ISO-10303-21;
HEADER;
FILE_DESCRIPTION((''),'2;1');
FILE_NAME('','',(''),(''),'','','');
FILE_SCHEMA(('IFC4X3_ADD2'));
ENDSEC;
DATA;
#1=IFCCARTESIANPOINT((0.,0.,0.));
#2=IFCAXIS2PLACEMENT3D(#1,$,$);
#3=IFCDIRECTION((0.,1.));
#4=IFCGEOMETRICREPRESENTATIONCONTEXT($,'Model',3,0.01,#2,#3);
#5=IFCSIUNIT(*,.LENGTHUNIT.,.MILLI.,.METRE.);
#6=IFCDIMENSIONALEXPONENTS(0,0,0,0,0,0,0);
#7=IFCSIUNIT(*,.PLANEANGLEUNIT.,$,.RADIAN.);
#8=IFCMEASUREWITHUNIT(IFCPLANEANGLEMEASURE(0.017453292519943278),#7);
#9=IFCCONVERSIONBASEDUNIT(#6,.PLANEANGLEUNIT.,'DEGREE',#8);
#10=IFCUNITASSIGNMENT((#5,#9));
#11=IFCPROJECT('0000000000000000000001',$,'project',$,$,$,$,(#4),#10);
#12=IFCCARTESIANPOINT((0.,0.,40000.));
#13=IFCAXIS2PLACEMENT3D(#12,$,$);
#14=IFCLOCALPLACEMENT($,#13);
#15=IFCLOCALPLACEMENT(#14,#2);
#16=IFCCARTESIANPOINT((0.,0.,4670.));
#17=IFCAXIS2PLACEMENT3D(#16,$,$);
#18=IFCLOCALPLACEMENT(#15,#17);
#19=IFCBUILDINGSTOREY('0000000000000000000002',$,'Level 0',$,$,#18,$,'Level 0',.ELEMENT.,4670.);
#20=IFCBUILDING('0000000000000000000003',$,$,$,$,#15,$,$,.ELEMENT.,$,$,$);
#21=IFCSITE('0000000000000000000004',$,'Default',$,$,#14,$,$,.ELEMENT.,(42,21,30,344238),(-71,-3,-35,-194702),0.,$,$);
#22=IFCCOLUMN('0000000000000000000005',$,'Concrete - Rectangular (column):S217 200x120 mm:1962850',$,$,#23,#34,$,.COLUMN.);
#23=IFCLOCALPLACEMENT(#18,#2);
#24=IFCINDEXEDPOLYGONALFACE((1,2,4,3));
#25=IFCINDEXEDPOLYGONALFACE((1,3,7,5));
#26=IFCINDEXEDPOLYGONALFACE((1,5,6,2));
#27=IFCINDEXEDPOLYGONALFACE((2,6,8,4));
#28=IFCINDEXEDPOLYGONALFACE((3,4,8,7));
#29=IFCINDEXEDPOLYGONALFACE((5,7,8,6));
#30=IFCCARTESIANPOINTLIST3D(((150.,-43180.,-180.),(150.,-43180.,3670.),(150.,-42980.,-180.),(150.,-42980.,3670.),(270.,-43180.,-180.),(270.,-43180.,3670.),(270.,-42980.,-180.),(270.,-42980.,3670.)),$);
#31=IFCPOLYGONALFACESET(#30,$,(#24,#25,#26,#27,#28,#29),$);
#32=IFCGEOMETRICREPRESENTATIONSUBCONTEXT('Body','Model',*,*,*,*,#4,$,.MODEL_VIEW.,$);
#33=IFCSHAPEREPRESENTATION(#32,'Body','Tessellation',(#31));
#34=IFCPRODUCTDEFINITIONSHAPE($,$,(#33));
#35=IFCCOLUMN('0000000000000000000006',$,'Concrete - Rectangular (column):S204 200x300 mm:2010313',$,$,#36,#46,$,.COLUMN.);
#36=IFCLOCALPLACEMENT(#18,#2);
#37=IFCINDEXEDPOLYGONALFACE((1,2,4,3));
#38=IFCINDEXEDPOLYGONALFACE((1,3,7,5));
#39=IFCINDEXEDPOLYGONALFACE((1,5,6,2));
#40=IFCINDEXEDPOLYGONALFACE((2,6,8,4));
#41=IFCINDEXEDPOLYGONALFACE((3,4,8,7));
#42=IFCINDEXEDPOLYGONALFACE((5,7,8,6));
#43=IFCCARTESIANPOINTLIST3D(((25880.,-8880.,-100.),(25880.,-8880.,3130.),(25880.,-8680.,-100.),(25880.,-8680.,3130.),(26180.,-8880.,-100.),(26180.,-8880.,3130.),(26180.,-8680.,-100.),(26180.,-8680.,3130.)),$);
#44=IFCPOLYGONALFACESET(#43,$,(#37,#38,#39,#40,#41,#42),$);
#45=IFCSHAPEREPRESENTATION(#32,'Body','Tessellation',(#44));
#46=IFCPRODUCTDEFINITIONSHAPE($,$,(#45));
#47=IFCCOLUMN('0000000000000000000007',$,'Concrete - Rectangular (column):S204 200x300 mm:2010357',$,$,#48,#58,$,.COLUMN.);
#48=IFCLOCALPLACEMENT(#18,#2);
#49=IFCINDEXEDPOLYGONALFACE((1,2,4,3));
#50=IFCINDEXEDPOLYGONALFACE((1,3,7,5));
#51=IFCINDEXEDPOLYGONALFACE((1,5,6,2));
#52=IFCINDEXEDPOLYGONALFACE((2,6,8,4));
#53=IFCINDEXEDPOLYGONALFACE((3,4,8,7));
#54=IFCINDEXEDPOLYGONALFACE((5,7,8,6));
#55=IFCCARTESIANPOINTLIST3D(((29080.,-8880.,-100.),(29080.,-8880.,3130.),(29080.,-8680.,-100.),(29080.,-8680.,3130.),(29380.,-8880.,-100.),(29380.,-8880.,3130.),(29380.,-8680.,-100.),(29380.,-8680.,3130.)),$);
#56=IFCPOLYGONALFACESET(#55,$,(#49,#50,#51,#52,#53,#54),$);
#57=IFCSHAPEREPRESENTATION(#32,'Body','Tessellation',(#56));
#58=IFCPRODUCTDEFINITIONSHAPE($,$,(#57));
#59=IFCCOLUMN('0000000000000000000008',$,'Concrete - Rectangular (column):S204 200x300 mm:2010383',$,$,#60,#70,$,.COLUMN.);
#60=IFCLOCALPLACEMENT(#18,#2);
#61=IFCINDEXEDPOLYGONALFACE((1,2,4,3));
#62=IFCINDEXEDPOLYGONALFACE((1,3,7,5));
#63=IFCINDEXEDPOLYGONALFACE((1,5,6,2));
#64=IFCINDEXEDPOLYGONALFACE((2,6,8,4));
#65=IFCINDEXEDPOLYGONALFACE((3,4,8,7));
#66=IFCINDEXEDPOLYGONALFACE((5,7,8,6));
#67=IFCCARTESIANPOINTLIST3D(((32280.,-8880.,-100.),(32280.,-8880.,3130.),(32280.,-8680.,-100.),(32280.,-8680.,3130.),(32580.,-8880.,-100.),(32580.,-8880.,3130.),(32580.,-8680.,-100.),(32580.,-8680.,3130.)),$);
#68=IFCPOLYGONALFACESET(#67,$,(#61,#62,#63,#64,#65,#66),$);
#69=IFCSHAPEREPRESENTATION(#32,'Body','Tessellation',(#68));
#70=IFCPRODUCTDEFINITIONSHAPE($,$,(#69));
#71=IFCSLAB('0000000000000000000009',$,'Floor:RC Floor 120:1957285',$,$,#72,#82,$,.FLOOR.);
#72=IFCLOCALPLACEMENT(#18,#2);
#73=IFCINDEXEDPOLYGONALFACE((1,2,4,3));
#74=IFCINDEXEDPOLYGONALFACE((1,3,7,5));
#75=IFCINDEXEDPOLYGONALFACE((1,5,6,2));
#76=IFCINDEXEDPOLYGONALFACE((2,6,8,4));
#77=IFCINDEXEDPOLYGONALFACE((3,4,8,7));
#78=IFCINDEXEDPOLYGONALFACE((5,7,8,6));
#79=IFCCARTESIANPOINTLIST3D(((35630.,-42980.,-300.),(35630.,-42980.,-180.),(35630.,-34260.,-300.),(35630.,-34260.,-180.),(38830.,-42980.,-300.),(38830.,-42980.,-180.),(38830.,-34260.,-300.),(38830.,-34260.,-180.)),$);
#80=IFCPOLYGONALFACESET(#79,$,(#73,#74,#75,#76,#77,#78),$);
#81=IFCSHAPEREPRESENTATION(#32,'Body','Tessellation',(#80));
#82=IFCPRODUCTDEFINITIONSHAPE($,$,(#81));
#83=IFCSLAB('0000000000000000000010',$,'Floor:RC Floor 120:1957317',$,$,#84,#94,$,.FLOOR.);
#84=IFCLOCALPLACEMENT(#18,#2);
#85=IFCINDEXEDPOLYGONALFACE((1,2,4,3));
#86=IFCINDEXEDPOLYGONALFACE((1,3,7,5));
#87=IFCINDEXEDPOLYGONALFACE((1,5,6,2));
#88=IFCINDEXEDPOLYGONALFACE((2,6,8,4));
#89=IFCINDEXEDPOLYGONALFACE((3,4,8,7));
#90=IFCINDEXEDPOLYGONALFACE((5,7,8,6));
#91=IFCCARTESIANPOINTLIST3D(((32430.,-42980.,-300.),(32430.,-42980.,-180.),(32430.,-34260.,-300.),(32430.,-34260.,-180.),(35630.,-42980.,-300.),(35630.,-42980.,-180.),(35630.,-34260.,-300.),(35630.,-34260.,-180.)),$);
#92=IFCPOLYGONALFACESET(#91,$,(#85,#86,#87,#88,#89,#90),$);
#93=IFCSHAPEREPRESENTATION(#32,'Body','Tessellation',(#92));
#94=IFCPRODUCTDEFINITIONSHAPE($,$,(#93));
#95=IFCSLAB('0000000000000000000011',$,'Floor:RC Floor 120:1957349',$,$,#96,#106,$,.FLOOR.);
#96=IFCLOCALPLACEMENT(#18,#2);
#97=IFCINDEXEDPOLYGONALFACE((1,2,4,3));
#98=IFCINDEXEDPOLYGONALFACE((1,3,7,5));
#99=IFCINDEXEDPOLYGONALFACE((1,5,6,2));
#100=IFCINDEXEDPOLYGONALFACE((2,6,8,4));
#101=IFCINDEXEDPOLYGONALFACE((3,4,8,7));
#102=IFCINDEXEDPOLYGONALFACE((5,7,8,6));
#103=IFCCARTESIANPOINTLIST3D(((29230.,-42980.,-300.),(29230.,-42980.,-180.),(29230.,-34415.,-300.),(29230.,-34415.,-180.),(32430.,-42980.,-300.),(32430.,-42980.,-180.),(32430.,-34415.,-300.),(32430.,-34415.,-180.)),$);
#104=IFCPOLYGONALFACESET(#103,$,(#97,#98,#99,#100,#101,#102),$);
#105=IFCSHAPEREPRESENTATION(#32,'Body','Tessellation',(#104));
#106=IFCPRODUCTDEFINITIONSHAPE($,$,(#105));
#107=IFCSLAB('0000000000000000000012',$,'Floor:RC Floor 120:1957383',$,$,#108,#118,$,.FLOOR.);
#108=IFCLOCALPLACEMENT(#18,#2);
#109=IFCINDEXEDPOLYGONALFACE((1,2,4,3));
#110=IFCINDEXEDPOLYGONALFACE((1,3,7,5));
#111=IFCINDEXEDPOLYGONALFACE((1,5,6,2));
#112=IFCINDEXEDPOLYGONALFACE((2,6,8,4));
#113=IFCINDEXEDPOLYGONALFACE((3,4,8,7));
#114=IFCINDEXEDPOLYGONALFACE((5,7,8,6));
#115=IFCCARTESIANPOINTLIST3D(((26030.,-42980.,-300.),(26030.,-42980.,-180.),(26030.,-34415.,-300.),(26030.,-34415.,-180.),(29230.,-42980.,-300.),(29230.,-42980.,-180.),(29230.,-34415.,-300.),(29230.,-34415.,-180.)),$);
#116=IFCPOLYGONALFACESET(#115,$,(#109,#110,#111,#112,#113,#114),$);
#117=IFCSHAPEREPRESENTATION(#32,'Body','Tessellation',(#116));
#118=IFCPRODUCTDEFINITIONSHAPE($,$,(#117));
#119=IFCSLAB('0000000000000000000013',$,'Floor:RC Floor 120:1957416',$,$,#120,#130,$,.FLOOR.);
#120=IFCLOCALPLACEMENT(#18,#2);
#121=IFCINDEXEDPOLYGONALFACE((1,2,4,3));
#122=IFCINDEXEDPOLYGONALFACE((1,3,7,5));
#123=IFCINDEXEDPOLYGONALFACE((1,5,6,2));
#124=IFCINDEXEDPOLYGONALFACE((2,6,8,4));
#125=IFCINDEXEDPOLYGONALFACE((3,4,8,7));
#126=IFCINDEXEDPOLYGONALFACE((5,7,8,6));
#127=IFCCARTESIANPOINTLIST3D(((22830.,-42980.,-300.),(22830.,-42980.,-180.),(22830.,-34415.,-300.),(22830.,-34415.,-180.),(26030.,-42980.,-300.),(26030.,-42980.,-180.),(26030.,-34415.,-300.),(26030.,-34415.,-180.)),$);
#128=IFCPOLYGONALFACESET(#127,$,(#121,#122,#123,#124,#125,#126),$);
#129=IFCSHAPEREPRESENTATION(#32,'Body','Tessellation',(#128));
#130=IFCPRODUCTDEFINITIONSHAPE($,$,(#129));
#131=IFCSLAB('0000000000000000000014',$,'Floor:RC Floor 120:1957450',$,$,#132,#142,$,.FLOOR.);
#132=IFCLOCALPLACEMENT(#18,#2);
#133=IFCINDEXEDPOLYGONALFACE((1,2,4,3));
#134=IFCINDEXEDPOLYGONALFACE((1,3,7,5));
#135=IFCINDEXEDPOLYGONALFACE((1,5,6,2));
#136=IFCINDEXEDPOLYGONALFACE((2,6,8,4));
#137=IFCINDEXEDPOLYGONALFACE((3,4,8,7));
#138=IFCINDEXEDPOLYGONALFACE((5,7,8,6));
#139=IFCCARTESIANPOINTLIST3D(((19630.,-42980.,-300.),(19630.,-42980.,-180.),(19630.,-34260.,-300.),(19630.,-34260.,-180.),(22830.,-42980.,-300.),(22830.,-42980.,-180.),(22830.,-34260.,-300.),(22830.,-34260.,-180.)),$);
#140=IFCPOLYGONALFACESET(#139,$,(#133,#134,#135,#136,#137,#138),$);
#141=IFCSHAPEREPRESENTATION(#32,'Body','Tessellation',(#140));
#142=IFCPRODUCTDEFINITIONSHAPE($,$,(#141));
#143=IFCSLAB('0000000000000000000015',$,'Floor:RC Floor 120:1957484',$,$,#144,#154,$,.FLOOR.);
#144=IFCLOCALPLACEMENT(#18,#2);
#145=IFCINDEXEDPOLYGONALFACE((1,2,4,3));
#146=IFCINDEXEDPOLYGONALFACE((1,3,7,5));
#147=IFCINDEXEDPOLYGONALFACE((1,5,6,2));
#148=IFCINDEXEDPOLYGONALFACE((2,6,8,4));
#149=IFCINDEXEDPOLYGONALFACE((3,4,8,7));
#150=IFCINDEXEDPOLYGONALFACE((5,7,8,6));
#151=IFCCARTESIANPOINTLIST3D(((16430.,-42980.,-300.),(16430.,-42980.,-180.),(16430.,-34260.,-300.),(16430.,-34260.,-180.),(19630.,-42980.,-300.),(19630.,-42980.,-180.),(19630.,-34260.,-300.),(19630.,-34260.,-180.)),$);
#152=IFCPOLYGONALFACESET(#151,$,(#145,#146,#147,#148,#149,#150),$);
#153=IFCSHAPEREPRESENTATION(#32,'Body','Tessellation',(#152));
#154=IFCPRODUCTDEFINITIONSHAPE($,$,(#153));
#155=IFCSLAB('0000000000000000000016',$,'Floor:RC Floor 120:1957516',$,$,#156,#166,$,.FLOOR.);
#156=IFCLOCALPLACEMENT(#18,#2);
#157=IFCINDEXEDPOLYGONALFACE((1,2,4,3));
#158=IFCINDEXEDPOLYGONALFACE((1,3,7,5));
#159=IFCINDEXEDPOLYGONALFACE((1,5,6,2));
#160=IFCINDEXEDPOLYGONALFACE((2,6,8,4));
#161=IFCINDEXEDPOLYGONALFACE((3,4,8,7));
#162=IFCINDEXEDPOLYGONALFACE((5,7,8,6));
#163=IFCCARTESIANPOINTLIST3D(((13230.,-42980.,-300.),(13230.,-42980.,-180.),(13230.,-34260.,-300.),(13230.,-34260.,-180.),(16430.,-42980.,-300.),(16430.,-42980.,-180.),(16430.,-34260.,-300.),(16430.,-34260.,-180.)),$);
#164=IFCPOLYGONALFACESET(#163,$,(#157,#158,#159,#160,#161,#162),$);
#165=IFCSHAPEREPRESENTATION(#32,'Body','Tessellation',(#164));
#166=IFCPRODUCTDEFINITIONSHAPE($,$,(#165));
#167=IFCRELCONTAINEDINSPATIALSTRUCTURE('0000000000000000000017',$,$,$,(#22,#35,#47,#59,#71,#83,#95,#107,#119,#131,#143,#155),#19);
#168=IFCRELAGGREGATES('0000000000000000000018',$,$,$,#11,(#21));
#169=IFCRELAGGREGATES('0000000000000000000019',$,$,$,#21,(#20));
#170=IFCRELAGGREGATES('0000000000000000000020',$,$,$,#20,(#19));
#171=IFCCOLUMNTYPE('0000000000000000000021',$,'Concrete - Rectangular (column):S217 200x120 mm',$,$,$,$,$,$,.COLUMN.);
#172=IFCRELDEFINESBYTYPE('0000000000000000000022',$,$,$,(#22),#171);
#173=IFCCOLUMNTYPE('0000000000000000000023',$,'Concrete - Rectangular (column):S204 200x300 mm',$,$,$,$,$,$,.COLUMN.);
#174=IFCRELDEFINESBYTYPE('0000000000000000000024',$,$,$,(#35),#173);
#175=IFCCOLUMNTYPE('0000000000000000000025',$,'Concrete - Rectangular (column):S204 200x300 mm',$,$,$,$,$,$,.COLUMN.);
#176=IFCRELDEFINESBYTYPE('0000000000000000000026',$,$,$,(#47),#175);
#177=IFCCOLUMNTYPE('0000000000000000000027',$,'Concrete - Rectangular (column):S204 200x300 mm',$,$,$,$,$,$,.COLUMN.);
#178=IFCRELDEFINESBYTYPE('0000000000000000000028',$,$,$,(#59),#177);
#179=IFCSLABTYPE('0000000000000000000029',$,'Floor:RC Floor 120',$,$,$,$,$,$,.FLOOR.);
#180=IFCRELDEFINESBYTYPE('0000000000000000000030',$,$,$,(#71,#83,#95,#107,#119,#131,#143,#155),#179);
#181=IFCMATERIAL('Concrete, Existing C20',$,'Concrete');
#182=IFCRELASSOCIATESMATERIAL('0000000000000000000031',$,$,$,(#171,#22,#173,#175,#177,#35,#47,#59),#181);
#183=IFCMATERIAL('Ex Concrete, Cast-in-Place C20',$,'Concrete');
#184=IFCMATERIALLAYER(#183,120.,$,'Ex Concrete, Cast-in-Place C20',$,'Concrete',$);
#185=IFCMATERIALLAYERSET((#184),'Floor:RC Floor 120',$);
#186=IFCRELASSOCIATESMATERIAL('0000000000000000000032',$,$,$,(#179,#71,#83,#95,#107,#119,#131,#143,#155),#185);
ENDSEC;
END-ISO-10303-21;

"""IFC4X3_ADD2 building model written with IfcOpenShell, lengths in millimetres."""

from ifc_helpers import new_model, entity, si_unit, converted_unit, direction, frame, frame_2d, origin, origin_2d_with_axis, place, context, subcontext, project, spatial, rectangle, extrude, source, transform, mapped, material, layer, layer_set, layer_usage, material_profile, profile_set, profile_usage, type_object, type_shapes, element, save


model = new_model("IFC4X3_ADD2")

# Units and contexts
model_context = context("Model", 3, precision=0.01, world=origin(), true_north=direction((0.0, 1.0)))
body_context = subcontext(model_context, "Body", "Model", "MODEL_VIEW")
ifc_project = project(units=[si_unit("LENGTHUNIT", "METRE", prefix="MILLI"), converted_unit("PLANEANGLEUNIT", "DEGREE", entity("IfcPlaneAngleMeasure", 0.017453292519943278), si_unit("PLANEANGLEUNIT", "RADIAN"), dimensions=[0, 0, 0, 0, 0, 0, 0])], contexts=[model_context])

# Site, building, storey
site_placement = place(None, frame((0.0, 0.0, 40000.0)))
site = spatial("IfcSite", under=ifc_project, at=site_placement, Name="Default", CompositionType="ELEMENT", RefLatitude=(42, 21, 30, 344238), RefLongitude=(-71, -3, -35, -194702), RefElevation=0.0)
building_placement = place(site_placement, origin())
building = spatial("IfcBuilding", under=site, at=building_placement, CompositionType="ELEMENT")
storey_placement = place(building_placement, frame((0.0, 0.0, 4670.0)))
storey = spatial("IfcBuildingStorey", under=building, at=storey_placement, Name="Level 0", LongName="Level 0", CompositionType="ELEMENT", Elevation=4670.0)

# Columns
ifc_material_1 = material(Name="Concrete, Existing C20", Category="Concrete")
ifc_material_profile_1 = material_profile(ifc_material_1, rectangle(XDim=200.0, YDim=120.0, at=frame_2d((0.0, 0.0), x_axis=(1.0, 0.0))), Name="S217 200x120 mm")
ifc_profile_set_1 = profile_set([ifc_material_profile_1], Name="S217 200x120 mm")
ifc_profile_usage_1 = profile_usage(ifc_profile_set_1)
column_type_1 = type_object("IfcColumnType", Name="Concrete - Rectangular (column):S217 200x120 mm", PredefinedType="COLUMN", material=ifc_profile_set_1)
shared_shape_1 = source(origin(), body_context, "Body", "SweptSolid", [
    extrude(rectangle(XDim=200.0, YDim=120.0, at=frame_2d((0.0, 0.0), x_axis=(1.0, 0.0))), frame((210.0, -43080.0, 4490.0), z_axis=(0.0, 0.0, 1.0), x_axis=(0.0, 1.0, 0.0)), (0.0, 0.0, 1.0), 3850.0),
])
type_shapes(column_type_1, [shared_shape_1])
column_1_placement = place(storey_placement, frame((0.0, 0.0, -4670.0)))
element("IfcColumn", 1, at=column_1_placement, inside=storey, type_object=column_type_1, material=ifc_profile_usage_1, Name="Concrete - Rectangular (column):S217 200x120 mm:1962850", PredefinedType="COLUMN", context=body_context, shape_type="MappedRepresentation", body=[
    mapped(shared_shape_1, transform((0.0, 0.0, 0.0), scale=1.0)),
])
ifc_material_profile_2 = material_profile(ifc_material_1, rectangle(XDim=200.0, YDim=300.0, at=frame_2d((0.0, 0.0), x_axis=(1.0, 0.0))), Name="S204 200x300 mm")
ifc_profile_set_2 = profile_set([ifc_material_profile_2], Name="S204 200x300 mm")
ifc_profile_usage_2 = profile_usage(ifc_profile_set_2)
column_type_2 = type_object("IfcColumnType", Name="Concrete - Rectangular (column):S204 200x300 mm", PredefinedType="COLUMN", material=ifc_profile_set_2)
shared_shape_2 = source(origin(), body_context, "Body", "SweptSolid", [
    extrude(rectangle(XDim=200.0, YDim=300.0, at=frame_2d((0.0, 0.0), x_axis=(1.0, 0.0))), frame((26030.0, -8780.0, 4570.0), z_axis=(0.0, 0.0, 1.0), x_axis=(0.0, 1.0, 0.0)), (0.0, 0.0, 1.0), 3230.0),
])
type_shapes(column_type_2, [shared_shape_2])
column_2_placement = place(storey_placement, frame((0.0, 0.0, -4670.0)))
element("IfcColumn", 2, at=column_2_placement, inside=storey, type_object=column_type_2, material=ifc_profile_usage_2, Name="Concrete - Rectangular (column):S204 200x300 mm:2010313", PredefinedType="COLUMN", context=body_context, shape_type="MappedRepresentation", body=[
    mapped(shared_shape_2, transform((0.0, 0.0, 0.0), scale=1.0)),
])
column_type_3 = type_object("IfcColumnType", Name="Concrete - Rectangular (column):S204 200x300 mm", PredefinedType="COLUMN", material=ifc_profile_set_2)
shared_shape_3 = source(origin(), body_context, "Body", "SweptSolid", [
    extrude(rectangle(XDim=200.0, YDim=300.0, at=frame_2d((0.0, 0.0), x_axis=(1.0, 0.0))), frame((29230.0, -8780.0, 4570.0), z_axis=(0.0, 0.0, 1.0), x_axis=(0.0, 1.0, 0.0)), (0.0, 0.0, 1.0), 3230.0),
])
type_shapes(column_type_3, [shared_shape_3])
column_3_placement = place(storey_placement, frame((0.0, 0.0, -4670.0)))
element("IfcColumn", 3, at=column_3_placement, inside=storey, type_object=column_type_3, material=ifc_profile_usage_2, Name="Concrete - Rectangular (column):S204 200x300 mm:2010357", PredefinedType="COLUMN", context=body_context, shape_type="MappedRepresentation", body=[
    mapped(shared_shape_3, transform((0.0, 0.0, 0.0), scale=1.0)),
])
column_type_4 = type_object("IfcColumnType", Name="Concrete - Rectangular (column):S204 200x300 mm", PredefinedType="COLUMN", material=ifc_profile_set_2)
shared_shape_4 = source(origin(), body_context, "Body", "SweptSolid", [
    extrude(rectangle(XDim=200.0, YDim=300.0, at=frame_2d((0.0, 0.0), x_axis=(1.0, 0.0))), frame((32430.0, -8780.0, 4570.0), z_axis=(0.0, 0.0, 1.0), x_axis=(0.0, 1.0, 0.0)), (0.0, 0.0, 1.0), 3230.0),
])
type_shapes(column_type_4, [shared_shape_4])
column_4_placement = place(storey_placement, frame((0.0, 0.0, -4670.0)))
element("IfcColumn", 4, at=column_4_placement, inside=storey, type_object=column_type_4, material=ifc_profile_usage_2, Name="Concrete - Rectangular (column):S204 200x300 mm:2010383", PredefinedType="COLUMN", context=body_context, shape_type="MappedRepresentation", body=[
    mapped(shared_shape_4, transform((0.0, 0.0, 0.0), scale=1.0)),
])

# Slabs
ifc_material_2 = material(Name="Ex Concrete, Cast-in-Place C20", Category="Concrete")
ifc_layer_1 = layer(ifc_material_2, 120.0, Name="Ex Concrete, Cast-in-Place C20", Category="Concrete")
ifc_layer_set_1 = layer_set([ifc_layer_1], Name="Floor:RC Floor 120")
ifc_layer_usage_1 = layer_usage(ifc_layer_set_1, "AXIS3", "POSITIVE", 0.0)
slab_type_1 = type_object("IfcSlabType", Name="Floor:RC Floor 120", PredefinedType="FLOOR", material=ifc_layer_set_1)
slab_1_placement = place(storey_placement, origin())
element("IfcSlab", 5, at=slab_1_placement, inside=storey, type_object=slab_type_1, material=ifc_layer_usage_1, Name="Floor:RC Floor 120:1957285", PredefinedType="FLOOR", context=body_context, shape_type="SweptSolid", body=[
    extrude(rectangle(XDim=8720.0, YDim=3200.0, at=frame_2d((0.0, 0.0), x_axis=(1.0, 0.0))), frame((37230.0, -38620.0, -180.0), z_axis=(0.0, 0.0, -1.0), x_axis=(0.0, 1.0, 0.0)), (0.0, 0.0, 1.0), 120.0),
])
ifc_layer_usage_2 = layer_usage(ifc_layer_set_1, "AXIS3", "POSITIVE", 0.0)
slab_2_placement = place(storey_placement, origin())
element("IfcSlab", 6, at=slab_2_placement, inside=storey, type_object=slab_type_1, material=ifc_layer_usage_2, Name="Floor:RC Floor 120:1957317", PredefinedType="FLOOR", context=body_context, shape_type="SweptSolid", body=[
    extrude(rectangle(XDim=8720.0, YDim=3200.0, at=frame_2d((0.0, 0.0), x_axis=(1.0, 0.0))), frame((34030.0, -38620.0, -180.0), z_axis=(0.0, 0.0, -1.0), x_axis=(0.0, 1.0, 0.0)), (0.0, 0.0, 1.0), 120.0),
])
ifc_layer_usage_3 = layer_usage(ifc_layer_set_1, "AXIS3", "POSITIVE", 0.0)
slab_3_placement = place(storey_placement, origin())
element("IfcSlab", 7, at=slab_3_placement, inside=storey, type_object=slab_type_1, material=ifc_layer_usage_3, Name="Floor:RC Floor 120:1957349", PredefinedType="FLOOR", context=body_context, shape_type="SweptSolid", body=[
    extrude(rectangle(XDim=8565.0, YDim=3200.0, at=frame_2d((0.0, 0.0), x_axis=(1.0, 0.0))), frame((30830.0, -38697.5, -180.0), z_axis=(0.0, 0.0, -1.0), x_axis=(0.0, 1.0, 0.0)), (0.0, 0.0, 1.0), 120.0),
])
ifc_layer_usage_4 = layer_usage(ifc_layer_set_1, "AXIS3", "POSITIVE", 0.0)
slab_4_placement = place(storey_placement, origin())
element("IfcSlab", 8, at=slab_4_placement, inside=storey, type_object=slab_type_1, material=ifc_layer_usage_4, Name="Floor:RC Floor 120:1957383", PredefinedType="FLOOR", context=body_context, shape_type="SweptSolid", body=[
    extrude(rectangle(XDim=8565.0, YDim=3200.0, at=frame_2d((0.0, 0.0), x_axis=(1.0, 0.0))), frame((27630.0, -38697.5, -180.0), z_axis=(0.0, 0.0, -1.0), x_axis=(0.0, 1.0, 0.0)), (0.0, 0.0, 1.0), 120.0),
])
ifc_layer_usage_5 = layer_usage(ifc_layer_set_1, "AXIS3", "POSITIVE", 0.0)
slab_5_placement = place(storey_placement, origin())
element("IfcSlab", 9, at=slab_5_placement, inside=storey, type_object=slab_type_1, material=ifc_layer_usage_5, Name="Floor:RC Floor 120:1957416", PredefinedType="FLOOR", context=body_context, shape_type="SweptSolid", body=[
    extrude(rectangle(XDim=8565.0, YDim=3200.0, at=origin_2d_with_axis()), frame((24430.0, -38697.5, -180.0), z_axis=(0.0, 0.0, -1.0), x_axis=(0.0, 1.0, 0.0)), (0.0, 0.0, 1.0), 120.0),
])
ifc_layer_usage_6 = layer_usage(ifc_layer_set_1, "AXIS3", "POSITIVE", 0.0)
slab_6_placement = place(storey_placement, origin())
element("IfcSlab", 10, at=slab_6_placement, inside=storey, type_object=slab_type_1, material=ifc_layer_usage_6, Name="Floor:RC Floor 120:1957450", PredefinedType="FLOOR", context=body_context, shape_type="SweptSolid", body=[
    extrude(rectangle(XDim=8720.0, YDim=3200.0, at=frame_2d((0.0, 0.0), x_axis=(1.0, 0.0))), frame((21230.0, -38620.0, -180.0), z_axis=(0.0, 0.0, -1.0), x_axis=(0.0, 1.0, 0.0)), (0.0, 0.0, 1.0), 120.0),
])
ifc_layer_usage_7 = layer_usage(ifc_layer_set_1, "AXIS3", "POSITIVE", 0.0)
slab_7_placement = place(storey_placement, origin())
element("IfcSlab", 11, at=slab_7_placement, inside=storey, type_object=slab_type_1, material=ifc_layer_usage_7, Name="Floor:RC Floor 120:1957484", PredefinedType="FLOOR", context=body_context, shape_type="SweptSolid", body=[
    extrude(rectangle(XDim=8720.0, YDim=3200.0, at=frame_2d((0.0, 0.0), x_axis=(1.0, 0.0))), frame((18030.0, -38620.0, -180.0), z_axis=(0.0, 0.0, -1.0), x_axis=(0.0, 1.0, 0.0)), (0.0, 0.0, 1.0), 120.0),
])
ifc_layer_usage_8 = layer_usage(ifc_layer_set_1, "AXIS3", "POSITIVE", 0.0)
slab_8_placement = place(storey_placement, origin())
element("IfcSlab", 12, at=slab_8_placement, inside=storey, type_object=slab_type_1, material=ifc_layer_usage_8, Name="Floor:RC Floor 120:1957516", PredefinedType="FLOOR", context=body_context, shape_type="SweptSolid", body=[
    extrude(rectangle(XDim=8720.0, YDim=3200.0, at=frame_2d((0.0, 0.0), x_axis=(1.0, 0.0))), frame((14830.0, -38620.0, -180.0), z_axis=(0.0, 0.0, -1.0), x_axis=(0.0, 1.0, 0.0)), (0.0, 0.0, 1.0), 120.0),
])

save(model, "model.ifc")
